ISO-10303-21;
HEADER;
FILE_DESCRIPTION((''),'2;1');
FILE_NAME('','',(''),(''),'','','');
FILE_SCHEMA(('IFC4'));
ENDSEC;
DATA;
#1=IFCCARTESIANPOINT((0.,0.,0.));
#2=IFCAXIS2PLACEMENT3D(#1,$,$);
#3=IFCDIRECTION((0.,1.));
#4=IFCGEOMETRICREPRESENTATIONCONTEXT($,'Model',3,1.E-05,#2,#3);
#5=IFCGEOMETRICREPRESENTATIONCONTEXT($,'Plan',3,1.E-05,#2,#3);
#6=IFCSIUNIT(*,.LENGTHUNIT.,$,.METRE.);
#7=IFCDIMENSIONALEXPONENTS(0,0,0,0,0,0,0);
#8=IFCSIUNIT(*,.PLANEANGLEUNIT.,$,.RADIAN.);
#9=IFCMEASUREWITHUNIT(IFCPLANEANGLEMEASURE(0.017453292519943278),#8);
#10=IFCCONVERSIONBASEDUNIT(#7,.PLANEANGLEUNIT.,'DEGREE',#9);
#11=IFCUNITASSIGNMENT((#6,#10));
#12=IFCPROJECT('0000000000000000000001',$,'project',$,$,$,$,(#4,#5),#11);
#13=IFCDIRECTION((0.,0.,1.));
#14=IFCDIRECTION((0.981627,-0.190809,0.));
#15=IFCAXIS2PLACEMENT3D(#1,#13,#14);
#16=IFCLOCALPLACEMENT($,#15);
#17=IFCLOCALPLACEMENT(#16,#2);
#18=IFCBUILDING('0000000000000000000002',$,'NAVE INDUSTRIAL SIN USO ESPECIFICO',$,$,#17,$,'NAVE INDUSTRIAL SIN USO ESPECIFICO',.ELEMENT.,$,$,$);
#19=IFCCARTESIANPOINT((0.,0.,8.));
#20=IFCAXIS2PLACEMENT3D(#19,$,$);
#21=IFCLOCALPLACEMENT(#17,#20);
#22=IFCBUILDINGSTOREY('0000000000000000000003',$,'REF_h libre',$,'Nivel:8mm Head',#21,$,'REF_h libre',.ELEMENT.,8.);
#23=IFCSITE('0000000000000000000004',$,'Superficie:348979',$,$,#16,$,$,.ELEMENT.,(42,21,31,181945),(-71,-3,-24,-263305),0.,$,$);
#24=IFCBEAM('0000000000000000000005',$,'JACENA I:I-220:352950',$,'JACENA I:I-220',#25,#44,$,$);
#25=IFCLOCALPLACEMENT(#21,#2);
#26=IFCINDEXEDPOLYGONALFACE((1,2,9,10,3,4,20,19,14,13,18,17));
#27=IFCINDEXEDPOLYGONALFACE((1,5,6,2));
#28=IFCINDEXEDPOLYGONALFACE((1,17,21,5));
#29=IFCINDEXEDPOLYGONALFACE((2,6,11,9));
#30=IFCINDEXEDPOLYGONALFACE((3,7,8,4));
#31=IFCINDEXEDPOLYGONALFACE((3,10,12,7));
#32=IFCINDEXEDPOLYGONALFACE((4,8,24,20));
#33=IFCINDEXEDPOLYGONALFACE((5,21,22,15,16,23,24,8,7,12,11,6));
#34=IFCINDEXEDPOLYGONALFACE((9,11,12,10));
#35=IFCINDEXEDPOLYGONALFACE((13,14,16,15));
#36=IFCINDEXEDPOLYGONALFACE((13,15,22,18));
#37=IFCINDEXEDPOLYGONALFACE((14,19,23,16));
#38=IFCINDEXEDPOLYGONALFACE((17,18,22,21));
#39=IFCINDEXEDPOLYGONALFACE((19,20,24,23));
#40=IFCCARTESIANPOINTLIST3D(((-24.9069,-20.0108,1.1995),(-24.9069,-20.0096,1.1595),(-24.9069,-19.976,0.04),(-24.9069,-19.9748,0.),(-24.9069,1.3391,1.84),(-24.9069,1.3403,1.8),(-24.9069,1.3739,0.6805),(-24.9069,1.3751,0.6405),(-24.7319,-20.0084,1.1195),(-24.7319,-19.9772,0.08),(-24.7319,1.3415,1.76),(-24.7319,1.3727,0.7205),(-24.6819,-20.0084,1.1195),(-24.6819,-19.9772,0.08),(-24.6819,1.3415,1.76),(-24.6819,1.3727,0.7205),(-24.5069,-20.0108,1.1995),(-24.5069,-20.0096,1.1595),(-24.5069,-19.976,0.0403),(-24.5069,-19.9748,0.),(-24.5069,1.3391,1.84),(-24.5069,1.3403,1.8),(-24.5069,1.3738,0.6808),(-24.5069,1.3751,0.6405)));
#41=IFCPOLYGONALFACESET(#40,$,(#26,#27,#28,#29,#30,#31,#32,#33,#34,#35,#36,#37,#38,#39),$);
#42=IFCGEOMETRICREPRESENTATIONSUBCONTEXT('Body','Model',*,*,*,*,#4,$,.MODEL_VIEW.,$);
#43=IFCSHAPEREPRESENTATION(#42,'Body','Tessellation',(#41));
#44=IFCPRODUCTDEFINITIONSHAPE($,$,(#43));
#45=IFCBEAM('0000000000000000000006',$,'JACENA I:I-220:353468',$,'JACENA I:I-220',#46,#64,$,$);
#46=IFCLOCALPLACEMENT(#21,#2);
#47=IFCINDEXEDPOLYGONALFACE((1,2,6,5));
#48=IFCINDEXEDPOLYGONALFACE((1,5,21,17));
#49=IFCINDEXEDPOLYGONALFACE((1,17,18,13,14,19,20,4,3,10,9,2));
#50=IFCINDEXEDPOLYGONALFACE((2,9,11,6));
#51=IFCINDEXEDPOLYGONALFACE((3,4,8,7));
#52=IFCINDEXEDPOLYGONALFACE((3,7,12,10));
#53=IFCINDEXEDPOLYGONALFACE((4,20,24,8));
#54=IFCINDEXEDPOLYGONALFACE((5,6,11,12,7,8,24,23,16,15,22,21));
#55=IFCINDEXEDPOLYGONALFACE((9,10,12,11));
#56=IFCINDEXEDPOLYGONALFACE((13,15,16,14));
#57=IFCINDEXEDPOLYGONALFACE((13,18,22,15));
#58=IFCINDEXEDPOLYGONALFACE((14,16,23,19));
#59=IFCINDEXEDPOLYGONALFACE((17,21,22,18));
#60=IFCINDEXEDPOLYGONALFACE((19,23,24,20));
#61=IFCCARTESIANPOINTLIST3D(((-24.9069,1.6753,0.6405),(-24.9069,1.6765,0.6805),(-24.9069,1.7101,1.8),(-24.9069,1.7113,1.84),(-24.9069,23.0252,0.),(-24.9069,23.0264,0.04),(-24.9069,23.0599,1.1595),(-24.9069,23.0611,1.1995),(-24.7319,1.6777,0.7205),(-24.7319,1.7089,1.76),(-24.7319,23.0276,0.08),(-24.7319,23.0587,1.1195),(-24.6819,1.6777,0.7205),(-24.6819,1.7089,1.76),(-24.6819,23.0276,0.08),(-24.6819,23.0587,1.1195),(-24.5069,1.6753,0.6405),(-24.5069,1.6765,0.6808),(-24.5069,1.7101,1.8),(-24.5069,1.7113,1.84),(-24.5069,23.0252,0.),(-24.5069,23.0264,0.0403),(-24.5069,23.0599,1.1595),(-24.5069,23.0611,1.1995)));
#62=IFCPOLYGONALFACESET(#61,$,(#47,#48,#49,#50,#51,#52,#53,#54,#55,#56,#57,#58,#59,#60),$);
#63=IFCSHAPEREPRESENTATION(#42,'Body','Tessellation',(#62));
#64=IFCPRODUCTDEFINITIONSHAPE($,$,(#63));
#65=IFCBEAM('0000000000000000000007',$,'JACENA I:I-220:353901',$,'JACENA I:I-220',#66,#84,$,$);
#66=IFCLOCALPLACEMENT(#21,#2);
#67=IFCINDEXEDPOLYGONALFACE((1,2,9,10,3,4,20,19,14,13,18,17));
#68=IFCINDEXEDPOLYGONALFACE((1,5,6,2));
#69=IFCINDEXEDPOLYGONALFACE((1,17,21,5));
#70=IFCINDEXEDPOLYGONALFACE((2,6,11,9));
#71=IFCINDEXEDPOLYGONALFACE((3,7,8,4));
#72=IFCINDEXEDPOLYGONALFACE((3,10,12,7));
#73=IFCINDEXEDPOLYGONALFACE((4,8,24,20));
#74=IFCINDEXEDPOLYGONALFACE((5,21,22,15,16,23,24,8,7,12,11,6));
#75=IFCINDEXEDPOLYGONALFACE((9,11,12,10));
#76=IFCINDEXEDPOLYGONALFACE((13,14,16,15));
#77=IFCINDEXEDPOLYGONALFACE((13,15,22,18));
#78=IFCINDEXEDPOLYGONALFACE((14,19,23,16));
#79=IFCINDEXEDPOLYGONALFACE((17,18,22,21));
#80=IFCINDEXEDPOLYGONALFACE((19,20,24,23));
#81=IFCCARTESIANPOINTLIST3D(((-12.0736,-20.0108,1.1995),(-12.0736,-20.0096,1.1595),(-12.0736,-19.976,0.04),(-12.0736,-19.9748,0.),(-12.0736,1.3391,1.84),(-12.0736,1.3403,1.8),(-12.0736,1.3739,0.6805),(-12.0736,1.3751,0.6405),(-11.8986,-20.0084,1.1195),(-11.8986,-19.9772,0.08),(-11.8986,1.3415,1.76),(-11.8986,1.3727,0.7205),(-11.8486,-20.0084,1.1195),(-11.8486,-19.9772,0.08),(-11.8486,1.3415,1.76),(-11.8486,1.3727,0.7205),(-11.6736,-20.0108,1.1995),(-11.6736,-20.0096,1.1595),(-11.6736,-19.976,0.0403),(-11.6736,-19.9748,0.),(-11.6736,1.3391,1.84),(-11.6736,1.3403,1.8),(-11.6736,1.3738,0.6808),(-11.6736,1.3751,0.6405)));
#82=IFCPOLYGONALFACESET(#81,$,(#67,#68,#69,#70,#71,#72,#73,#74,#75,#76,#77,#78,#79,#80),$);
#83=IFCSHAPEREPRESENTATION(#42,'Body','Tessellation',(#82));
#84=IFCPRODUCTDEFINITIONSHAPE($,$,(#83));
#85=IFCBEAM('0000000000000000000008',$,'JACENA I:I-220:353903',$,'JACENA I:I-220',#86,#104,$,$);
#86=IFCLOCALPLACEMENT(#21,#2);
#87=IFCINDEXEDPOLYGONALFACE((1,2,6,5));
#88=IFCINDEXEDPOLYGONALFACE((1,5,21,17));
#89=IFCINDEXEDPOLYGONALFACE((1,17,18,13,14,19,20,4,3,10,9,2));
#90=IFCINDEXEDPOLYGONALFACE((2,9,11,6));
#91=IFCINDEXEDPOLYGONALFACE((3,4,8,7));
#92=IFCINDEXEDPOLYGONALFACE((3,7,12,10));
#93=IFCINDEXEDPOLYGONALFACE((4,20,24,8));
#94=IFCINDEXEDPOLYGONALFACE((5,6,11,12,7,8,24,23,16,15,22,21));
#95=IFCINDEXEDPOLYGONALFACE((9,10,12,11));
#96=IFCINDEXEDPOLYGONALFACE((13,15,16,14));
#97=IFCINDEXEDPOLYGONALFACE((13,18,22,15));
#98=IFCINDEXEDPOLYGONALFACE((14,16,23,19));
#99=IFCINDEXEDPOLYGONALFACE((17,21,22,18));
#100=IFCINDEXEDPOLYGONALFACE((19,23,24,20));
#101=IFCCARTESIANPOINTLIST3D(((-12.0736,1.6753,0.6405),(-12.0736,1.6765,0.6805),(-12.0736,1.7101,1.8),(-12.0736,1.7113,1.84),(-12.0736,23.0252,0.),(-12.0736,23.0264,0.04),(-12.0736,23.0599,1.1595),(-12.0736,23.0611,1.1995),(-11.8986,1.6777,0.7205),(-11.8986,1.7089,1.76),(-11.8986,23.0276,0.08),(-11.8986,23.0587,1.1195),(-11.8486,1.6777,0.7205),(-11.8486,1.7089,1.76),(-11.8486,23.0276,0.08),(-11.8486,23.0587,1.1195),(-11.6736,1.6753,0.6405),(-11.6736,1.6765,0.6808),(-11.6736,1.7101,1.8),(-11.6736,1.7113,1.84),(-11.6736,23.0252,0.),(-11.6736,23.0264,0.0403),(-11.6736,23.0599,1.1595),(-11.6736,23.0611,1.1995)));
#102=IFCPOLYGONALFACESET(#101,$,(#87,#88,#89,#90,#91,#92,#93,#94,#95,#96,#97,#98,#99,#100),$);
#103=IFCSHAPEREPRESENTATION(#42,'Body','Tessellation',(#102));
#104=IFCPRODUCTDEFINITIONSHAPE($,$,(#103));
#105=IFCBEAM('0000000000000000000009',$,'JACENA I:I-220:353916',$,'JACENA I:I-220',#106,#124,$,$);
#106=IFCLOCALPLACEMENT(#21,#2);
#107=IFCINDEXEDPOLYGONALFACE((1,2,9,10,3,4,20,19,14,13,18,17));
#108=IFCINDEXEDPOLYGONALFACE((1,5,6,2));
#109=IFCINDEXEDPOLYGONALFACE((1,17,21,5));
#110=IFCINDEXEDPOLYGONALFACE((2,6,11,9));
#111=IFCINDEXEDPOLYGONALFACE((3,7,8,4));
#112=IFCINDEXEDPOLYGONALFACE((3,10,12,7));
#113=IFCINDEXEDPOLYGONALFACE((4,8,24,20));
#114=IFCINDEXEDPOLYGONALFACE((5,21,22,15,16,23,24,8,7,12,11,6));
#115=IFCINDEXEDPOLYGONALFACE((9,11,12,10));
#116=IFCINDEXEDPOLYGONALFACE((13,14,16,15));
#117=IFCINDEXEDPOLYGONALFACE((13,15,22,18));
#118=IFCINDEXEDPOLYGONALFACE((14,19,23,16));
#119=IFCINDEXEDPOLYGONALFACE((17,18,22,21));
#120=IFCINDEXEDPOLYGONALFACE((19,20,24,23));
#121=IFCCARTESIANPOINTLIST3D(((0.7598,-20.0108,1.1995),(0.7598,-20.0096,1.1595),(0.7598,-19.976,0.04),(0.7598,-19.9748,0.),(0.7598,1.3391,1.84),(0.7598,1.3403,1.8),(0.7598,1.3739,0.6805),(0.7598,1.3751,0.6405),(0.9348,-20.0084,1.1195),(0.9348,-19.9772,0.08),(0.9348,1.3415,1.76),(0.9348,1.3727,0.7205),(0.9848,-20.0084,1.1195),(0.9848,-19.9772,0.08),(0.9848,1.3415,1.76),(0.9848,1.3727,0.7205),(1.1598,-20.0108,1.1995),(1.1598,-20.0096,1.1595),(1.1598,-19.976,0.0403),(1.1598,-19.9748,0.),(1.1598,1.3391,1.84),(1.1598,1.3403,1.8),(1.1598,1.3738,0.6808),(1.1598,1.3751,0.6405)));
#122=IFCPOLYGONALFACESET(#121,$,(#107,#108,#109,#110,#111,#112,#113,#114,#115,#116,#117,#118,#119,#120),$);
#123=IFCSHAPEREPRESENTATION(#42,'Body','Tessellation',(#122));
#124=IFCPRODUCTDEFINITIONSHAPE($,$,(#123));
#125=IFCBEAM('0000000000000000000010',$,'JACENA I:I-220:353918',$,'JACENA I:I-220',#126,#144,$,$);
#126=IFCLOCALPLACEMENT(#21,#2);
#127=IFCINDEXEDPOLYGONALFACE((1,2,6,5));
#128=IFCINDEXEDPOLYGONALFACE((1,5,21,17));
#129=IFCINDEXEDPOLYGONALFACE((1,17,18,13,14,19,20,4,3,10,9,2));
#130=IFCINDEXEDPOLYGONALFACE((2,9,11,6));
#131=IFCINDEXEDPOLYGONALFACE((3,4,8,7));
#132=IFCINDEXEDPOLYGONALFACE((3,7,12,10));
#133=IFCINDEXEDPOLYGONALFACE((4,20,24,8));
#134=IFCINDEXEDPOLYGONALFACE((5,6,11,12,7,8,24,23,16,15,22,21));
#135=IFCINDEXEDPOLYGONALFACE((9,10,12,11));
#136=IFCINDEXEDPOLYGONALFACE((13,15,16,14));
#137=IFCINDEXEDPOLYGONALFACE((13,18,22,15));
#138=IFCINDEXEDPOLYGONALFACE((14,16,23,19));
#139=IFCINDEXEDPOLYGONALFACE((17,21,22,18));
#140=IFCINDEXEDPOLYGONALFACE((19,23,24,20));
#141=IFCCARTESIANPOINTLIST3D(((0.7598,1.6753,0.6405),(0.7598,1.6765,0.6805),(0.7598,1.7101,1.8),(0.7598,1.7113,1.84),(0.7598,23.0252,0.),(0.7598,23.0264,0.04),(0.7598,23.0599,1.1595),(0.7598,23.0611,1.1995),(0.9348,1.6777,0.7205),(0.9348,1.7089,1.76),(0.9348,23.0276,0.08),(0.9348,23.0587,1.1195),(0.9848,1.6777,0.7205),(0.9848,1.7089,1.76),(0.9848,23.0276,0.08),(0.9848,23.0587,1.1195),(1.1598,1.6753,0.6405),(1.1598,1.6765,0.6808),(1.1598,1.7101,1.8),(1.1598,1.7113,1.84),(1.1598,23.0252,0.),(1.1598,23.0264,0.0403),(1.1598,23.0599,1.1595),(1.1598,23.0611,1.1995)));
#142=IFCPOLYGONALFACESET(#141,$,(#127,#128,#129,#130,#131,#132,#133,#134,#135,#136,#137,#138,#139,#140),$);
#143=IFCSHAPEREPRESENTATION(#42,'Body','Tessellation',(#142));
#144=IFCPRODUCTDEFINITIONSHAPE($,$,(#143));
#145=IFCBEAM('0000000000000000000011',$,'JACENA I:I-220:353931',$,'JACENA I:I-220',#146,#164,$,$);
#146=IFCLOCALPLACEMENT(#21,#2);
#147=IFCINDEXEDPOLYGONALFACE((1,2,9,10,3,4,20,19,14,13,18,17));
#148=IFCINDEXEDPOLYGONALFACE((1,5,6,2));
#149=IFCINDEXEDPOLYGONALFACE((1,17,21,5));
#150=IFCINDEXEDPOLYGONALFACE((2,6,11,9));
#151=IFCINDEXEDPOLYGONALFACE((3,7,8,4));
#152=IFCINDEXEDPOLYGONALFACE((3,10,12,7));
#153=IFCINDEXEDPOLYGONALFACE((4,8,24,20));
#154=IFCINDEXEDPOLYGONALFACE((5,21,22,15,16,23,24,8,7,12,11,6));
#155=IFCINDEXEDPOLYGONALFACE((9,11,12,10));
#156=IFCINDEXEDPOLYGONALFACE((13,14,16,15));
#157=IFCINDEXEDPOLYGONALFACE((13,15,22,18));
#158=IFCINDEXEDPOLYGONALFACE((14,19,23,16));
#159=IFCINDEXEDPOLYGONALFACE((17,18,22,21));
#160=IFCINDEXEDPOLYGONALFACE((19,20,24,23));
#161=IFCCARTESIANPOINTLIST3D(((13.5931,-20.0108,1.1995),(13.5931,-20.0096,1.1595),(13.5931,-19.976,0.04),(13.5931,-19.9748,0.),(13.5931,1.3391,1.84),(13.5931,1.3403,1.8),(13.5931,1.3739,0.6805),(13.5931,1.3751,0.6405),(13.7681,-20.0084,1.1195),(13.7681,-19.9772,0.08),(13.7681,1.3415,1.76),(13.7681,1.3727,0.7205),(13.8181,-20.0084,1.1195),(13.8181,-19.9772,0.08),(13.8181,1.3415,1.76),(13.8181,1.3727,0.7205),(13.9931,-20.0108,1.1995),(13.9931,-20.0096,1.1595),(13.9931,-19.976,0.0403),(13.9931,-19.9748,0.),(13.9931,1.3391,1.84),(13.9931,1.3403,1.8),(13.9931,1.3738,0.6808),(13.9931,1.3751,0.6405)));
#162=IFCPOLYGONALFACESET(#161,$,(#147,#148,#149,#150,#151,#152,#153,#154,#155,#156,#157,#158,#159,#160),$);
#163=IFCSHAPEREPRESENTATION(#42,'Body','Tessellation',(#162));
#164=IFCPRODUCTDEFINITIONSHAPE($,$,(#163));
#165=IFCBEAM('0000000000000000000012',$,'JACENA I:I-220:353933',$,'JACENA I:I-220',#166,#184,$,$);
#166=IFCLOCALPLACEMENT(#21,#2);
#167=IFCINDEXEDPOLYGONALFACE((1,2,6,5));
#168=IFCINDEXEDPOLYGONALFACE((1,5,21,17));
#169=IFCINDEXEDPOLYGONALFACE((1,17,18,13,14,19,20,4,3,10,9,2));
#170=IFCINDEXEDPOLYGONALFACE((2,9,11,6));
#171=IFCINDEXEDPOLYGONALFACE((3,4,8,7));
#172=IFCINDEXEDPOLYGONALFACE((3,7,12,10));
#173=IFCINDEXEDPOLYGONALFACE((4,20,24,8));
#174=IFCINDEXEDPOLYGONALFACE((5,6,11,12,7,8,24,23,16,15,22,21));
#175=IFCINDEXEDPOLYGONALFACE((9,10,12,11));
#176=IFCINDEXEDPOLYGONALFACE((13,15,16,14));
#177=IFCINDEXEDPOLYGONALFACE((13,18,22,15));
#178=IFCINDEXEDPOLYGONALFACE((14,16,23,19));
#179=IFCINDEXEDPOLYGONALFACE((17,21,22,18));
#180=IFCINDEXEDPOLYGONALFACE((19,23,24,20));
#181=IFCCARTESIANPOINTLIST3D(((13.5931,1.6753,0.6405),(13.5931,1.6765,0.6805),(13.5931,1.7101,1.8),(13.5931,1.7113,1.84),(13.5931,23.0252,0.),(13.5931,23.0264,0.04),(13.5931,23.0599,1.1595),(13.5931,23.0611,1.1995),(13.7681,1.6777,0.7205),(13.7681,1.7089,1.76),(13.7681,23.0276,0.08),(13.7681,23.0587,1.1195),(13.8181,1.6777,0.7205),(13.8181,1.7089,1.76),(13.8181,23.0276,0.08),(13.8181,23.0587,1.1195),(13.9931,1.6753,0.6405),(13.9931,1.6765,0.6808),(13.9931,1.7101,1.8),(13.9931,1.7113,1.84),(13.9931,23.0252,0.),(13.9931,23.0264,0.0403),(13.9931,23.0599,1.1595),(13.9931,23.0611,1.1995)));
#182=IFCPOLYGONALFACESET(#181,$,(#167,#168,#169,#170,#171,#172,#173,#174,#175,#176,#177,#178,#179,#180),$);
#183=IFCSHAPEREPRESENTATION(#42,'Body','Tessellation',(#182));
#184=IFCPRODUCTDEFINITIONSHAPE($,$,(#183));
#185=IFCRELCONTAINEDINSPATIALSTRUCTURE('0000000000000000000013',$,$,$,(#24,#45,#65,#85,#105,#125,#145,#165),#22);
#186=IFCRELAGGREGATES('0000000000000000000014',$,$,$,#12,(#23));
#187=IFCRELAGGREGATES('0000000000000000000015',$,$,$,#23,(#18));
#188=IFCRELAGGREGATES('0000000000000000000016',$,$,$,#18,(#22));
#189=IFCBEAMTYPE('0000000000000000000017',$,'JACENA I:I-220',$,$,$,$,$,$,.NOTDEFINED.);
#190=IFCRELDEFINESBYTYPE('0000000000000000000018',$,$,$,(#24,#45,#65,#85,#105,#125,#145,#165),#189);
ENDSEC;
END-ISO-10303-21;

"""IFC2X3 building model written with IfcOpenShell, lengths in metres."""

from ifc_helpers import new_model, entity, si_unit, converted_unit, direction, frame, origin, place, context, subcontext, project, spatial, polyline, outline, extrude, type_object, element, save


model = new_model("IFC2X3")

# Units and contexts
model_context = context("Model", 3, precision=1e-05, world=origin(), true_north=direction((0.0, 1.0)))
plan_context = context("Plan", 3, precision=1e-05, world=origin(), true_north=direction((0.0, 1.0)))
body_context = subcontext(model_context, "Body", "Model", "MODEL_VIEW")
ifc_project = project(units=[si_unit("LENGTHUNIT", "METRE"), converted_unit("PLANEANGLEUNIT", "DEGREE", entity("IfcPlaneAngleMeasure", 0.017453292519943278), si_unit("PLANEANGLEUNIT", "RADIAN"), dimensions=[0, 0, 0, 0, 0, 0, 0])], contexts=[model_context, plan_context])

# Site, building, storey
site_placement = place(None, frame((0.0, 0.0, 0.0), z_axis=(0.0, 0.0, 1.0), x_axis=(0.981627, -0.190809, 0.0)))
site = spatial("IfcSite", under=ifc_project, at=site_placement, Name="Superficie:348979", CompositionType="ELEMENT", RefLatitude=(42, 21, 31, 181945), RefLongitude=(-71, -3, -24, -263305), RefElevation=0.0)
building_placement = place(site_placement, origin())
building = spatial("IfcBuilding", under=site, at=building_placement, Name="NAVE INDUSTRIAL SIN USO ESPECIFICO", LongName="NAVE INDUSTRIAL SIN USO ESPECIFICO", CompositionType="ELEMENT")
storey_placement = place(building_placement, frame((0.0, 0.0, 8.0)))
storey = spatial("IfcBuildingStorey", under=building, at=storey_placement, Name="REF_h libre", ObjectType="Nivel:8mm Head", LongName="REF_h libre", CompositionType="ELEMENT", Elevation=8.0)

# Beams
beam_type = type_object("IfcBeamType", Name="JACENA I:I-220", PredefinedType="NOTDEFINED")
beam_1_placement = place(storey_placement, frame((-24.7069, -19.9748, 0.0), z_axis=(0.0, -0.029987, 0.99955), x_axis=(0.0, 0.99955, 0.029987)))
element("IfcBeam", 1, at=beam_1_placement, inside=storey, type_object=beam_type, Name="JACENA I:I-220:352950", ObjectType="JACENA I:I-220", context=body_context, shape_type="SweptSolid", body=[
    extrude(outline(polyline([(-0.6, -0.2), (-0.56, -0.2), (-0.52, -0.025), (0.52, -0.025), (0.5597, -0.2), (0.6, -0.2), (0.6, 0.2), (0.56, 0.2), (0.52, 0.025), (-0.52, 0.025), (-0.56, 0.2), (-0.6, 0.2), (-0.6, -0.2)])), frame((0.0, 0.0, 0.6), z_axis=(1.0, 0.0, 0.0), x_axis=(0.0, 0.0, -1.0)), (0.0, 0.0, 1.0), 21.3595),
])
beam_2_placement = place(storey_placement, frame((-24.7069, 23.0252, 0.0), z_axis=(0.0, 0.029987, 0.99955), x_axis=(0.0, -0.99955, 0.029987)))
element("IfcBeam", 2, at=beam_2_placement, inside=storey, type_object=beam_type, Name="JACENA I:I-220:353468", ObjectType="JACENA I:I-220", context=body_context, shape_type="SweptSolid", body=[
    extrude(outline(polyline([(-0.6, -0.2), (-0.56, -0.2), (-0.52, -0.025), (0.52, -0.025), (0.56, -0.2), (0.6, -0.2), (0.6, 0.2), (0.5597, 0.2), (0.52, 0.025), (-0.52, 0.025), (-0.56, 0.2), (-0.6, 0.2), (-0.6, -0.2)])), frame((0.0, 0.0, 0.6), z_axis=(1.0, 0.0, 0.0), x_axis=(0.0, 0.0, -1.0)), (0.0, 0.0, 1.0), 21.3595),
])
beam_3_placement = place(storey_placement, frame((-11.8736, -19.9748, 0.0), z_axis=(0.0, -0.029987, 0.99955), x_axis=(0.0, 0.99955, 0.029987)))
element("IfcBeam", 3, at=beam_3_placement, inside=storey, type_object=beam_type, Name="JACENA I:I-220:353901", ObjectType="JACENA I:I-220", context=body_context, shape_type="SweptSolid", body=[
    extrude(outline(polyline([(-0.6, -0.2), (-0.56, -0.2), (-0.52, -0.025), (0.52, -0.025), (0.5597, -0.2), (0.6, -0.2), (0.6, 0.2), (0.56, 0.2), (0.52, 0.025), (-0.52, 0.025), (-0.56, 0.2), (-0.6, 0.2), (-0.6, -0.2)])), frame((0.0, 0.0, 0.6), z_axis=(1.0, 0.0, 0.0), x_axis=(0.0, 0.0, -1.0)), (0.0, 0.0, 1.0), 21.3595),
])
beam_4_placement = place(storey_placement, frame((-11.8736, 23.0252, 0.0), z_axis=(0.0, 0.029987, 0.99955), x_axis=(0.0, -0.99955, 0.029987)))
element("IfcBeam", 4, at=beam_4_placement, inside=storey, type_object=beam_type, Name="JACENA I:I-220:353903", ObjectType="JACENA I:I-220", context=body_context, shape_type="SweptSolid", body=[
    extrude(outline(polyline([(-0.6, -0.2), (-0.56, -0.2), (-0.52, -0.025), (0.52, -0.025), (0.56, -0.2), (0.6, -0.2), (0.6, 0.2), (0.5597, 0.2), (0.52, 0.025), (-0.52, 0.025), (-0.56, 0.2), (-0.6, 0.2), (-0.6, -0.2)])), frame((0.0, 0.0, 0.6), z_axis=(1.0, 0.0, 0.0), x_axis=(0.0, 0.0, -1.0)), (0.0, 0.0, 1.0), 21.3595),
])
beam_5_placement = place(storey_placement, frame((0.9598, -19.9748, 0.0), z_axis=(0.0, -0.029987, 0.99955), x_axis=(0.0, 0.99955, 0.029987)))
element("IfcBeam", 5, at=beam_5_placement, inside=storey, type_object=beam_type, Name="JACENA I:I-220:353916", ObjectType="JACENA I:I-220", context=body_context, shape_type="SweptSolid", body=[
    extrude(outline(polyline([(-0.6, -0.2), (-0.56, -0.2), (-0.52, -0.025), (0.52, -0.025), (0.5597, -0.2), (0.6, -0.2), (0.6, 0.2), (0.56, 0.2), (0.52, 0.025), (-0.52, 0.025), (-0.56, 0.2), (-0.6, 0.2), (-0.6, -0.2)])), frame((0.0, 0.0, 0.6), z_axis=(1.0, 0.0, 0.0), x_axis=(0.0, 0.0, -1.0)), (0.0, 0.0, 1.0), 21.3595),
])
beam_6_placement = place(storey_placement, frame((0.9598, 23.0252, 0.0), z_axis=(0.0, 0.029987, 0.99955), x_axis=(0.0, -0.99955, 0.029987)))
element("IfcBeam", 6, at=beam_6_placement, inside=storey, type_object=beam_type, Name="JACENA I:I-220:353918", ObjectType="JACENA I:I-220", context=body_context, shape_type="SweptSolid", body=[
    extrude(outline(polyline([(-0.6, -0.2), (-0.56, -0.2), (-0.52, -0.025), (0.52, -0.025), (0.56, -0.2), (0.6, -0.2), (0.6, 0.2), (0.5597, 0.2), (0.52, 0.025), (-0.52, 0.025), (-0.56, 0.2), (-0.6, 0.2), (-0.6, -0.2)])), frame((0.0, 0.0, 0.6), z_axis=(1.0, 0.0, 0.0), x_axis=(0.0, 0.0, -1.0)), (0.0, 0.0, 1.0), 21.3595),
])
beam_7_placement = place(storey_placement, frame((13.7931, -19.9748, 0.0), z_axis=(0.0, -0.029987, 0.99955), x_axis=(0.0, 0.99955, 0.029987)))
element("IfcBeam", 7, at=beam_7_placement, inside=storey, type_object=beam_type, Name="JACENA I:I-220:353931", ObjectType="JACENA I:I-220", context=body_context, shape_type="SweptSolid", body=[
    extrude(outline(polyline([(-0.6, -0.2), (-0.56, -0.2), (-0.52, -0.025), (0.52, -0.025), (0.5597, -0.2), (0.6, -0.2), (0.6, 0.2), (0.56, 0.2), (0.52, 0.025), (-0.52, 0.025), (-0.56, 0.2), (-0.6, 0.2), (-0.6, -0.2)])), frame((0.0, 0.0, 0.6), z_axis=(1.0, 0.0, 0.0), x_axis=(0.0, 0.0, -1.0)), (0.0, 0.0, 1.0), 21.3595),
])
beam_8_placement = place(storey_placement, frame((13.7931, 23.0252, 0.0), z_axis=(0.0, 0.029987, 0.99955), x_axis=(0.0, -0.99955, 0.029987)))
element("IfcBeam", 8, at=beam_8_placement, inside=storey, type_object=beam_type, Name="JACENA I:I-220:353933", ObjectType="JACENA I:I-220", context=body_context, shape_type="SweptSolid", body=[
    extrude(outline(polyline([(-0.6, -0.2), (-0.56, -0.2), (-0.52, -0.025), (0.52, -0.025), (0.56, -0.2), (0.6, -0.2), (0.6, 0.2), (0.5597, 0.2), (0.52, 0.025), (-0.52, 0.025), (-0.56, 0.2), (-0.6, 0.2), (-0.6, -0.2)])), frame((0.0, 0.0, 0.6), z_axis=(1.0, 0.0, 0.0), x_axis=(0.0, 0.0, -1.0)), (0.0, 0.0, 1.0), 21.3595),
])

save(model, "model.ifc")
